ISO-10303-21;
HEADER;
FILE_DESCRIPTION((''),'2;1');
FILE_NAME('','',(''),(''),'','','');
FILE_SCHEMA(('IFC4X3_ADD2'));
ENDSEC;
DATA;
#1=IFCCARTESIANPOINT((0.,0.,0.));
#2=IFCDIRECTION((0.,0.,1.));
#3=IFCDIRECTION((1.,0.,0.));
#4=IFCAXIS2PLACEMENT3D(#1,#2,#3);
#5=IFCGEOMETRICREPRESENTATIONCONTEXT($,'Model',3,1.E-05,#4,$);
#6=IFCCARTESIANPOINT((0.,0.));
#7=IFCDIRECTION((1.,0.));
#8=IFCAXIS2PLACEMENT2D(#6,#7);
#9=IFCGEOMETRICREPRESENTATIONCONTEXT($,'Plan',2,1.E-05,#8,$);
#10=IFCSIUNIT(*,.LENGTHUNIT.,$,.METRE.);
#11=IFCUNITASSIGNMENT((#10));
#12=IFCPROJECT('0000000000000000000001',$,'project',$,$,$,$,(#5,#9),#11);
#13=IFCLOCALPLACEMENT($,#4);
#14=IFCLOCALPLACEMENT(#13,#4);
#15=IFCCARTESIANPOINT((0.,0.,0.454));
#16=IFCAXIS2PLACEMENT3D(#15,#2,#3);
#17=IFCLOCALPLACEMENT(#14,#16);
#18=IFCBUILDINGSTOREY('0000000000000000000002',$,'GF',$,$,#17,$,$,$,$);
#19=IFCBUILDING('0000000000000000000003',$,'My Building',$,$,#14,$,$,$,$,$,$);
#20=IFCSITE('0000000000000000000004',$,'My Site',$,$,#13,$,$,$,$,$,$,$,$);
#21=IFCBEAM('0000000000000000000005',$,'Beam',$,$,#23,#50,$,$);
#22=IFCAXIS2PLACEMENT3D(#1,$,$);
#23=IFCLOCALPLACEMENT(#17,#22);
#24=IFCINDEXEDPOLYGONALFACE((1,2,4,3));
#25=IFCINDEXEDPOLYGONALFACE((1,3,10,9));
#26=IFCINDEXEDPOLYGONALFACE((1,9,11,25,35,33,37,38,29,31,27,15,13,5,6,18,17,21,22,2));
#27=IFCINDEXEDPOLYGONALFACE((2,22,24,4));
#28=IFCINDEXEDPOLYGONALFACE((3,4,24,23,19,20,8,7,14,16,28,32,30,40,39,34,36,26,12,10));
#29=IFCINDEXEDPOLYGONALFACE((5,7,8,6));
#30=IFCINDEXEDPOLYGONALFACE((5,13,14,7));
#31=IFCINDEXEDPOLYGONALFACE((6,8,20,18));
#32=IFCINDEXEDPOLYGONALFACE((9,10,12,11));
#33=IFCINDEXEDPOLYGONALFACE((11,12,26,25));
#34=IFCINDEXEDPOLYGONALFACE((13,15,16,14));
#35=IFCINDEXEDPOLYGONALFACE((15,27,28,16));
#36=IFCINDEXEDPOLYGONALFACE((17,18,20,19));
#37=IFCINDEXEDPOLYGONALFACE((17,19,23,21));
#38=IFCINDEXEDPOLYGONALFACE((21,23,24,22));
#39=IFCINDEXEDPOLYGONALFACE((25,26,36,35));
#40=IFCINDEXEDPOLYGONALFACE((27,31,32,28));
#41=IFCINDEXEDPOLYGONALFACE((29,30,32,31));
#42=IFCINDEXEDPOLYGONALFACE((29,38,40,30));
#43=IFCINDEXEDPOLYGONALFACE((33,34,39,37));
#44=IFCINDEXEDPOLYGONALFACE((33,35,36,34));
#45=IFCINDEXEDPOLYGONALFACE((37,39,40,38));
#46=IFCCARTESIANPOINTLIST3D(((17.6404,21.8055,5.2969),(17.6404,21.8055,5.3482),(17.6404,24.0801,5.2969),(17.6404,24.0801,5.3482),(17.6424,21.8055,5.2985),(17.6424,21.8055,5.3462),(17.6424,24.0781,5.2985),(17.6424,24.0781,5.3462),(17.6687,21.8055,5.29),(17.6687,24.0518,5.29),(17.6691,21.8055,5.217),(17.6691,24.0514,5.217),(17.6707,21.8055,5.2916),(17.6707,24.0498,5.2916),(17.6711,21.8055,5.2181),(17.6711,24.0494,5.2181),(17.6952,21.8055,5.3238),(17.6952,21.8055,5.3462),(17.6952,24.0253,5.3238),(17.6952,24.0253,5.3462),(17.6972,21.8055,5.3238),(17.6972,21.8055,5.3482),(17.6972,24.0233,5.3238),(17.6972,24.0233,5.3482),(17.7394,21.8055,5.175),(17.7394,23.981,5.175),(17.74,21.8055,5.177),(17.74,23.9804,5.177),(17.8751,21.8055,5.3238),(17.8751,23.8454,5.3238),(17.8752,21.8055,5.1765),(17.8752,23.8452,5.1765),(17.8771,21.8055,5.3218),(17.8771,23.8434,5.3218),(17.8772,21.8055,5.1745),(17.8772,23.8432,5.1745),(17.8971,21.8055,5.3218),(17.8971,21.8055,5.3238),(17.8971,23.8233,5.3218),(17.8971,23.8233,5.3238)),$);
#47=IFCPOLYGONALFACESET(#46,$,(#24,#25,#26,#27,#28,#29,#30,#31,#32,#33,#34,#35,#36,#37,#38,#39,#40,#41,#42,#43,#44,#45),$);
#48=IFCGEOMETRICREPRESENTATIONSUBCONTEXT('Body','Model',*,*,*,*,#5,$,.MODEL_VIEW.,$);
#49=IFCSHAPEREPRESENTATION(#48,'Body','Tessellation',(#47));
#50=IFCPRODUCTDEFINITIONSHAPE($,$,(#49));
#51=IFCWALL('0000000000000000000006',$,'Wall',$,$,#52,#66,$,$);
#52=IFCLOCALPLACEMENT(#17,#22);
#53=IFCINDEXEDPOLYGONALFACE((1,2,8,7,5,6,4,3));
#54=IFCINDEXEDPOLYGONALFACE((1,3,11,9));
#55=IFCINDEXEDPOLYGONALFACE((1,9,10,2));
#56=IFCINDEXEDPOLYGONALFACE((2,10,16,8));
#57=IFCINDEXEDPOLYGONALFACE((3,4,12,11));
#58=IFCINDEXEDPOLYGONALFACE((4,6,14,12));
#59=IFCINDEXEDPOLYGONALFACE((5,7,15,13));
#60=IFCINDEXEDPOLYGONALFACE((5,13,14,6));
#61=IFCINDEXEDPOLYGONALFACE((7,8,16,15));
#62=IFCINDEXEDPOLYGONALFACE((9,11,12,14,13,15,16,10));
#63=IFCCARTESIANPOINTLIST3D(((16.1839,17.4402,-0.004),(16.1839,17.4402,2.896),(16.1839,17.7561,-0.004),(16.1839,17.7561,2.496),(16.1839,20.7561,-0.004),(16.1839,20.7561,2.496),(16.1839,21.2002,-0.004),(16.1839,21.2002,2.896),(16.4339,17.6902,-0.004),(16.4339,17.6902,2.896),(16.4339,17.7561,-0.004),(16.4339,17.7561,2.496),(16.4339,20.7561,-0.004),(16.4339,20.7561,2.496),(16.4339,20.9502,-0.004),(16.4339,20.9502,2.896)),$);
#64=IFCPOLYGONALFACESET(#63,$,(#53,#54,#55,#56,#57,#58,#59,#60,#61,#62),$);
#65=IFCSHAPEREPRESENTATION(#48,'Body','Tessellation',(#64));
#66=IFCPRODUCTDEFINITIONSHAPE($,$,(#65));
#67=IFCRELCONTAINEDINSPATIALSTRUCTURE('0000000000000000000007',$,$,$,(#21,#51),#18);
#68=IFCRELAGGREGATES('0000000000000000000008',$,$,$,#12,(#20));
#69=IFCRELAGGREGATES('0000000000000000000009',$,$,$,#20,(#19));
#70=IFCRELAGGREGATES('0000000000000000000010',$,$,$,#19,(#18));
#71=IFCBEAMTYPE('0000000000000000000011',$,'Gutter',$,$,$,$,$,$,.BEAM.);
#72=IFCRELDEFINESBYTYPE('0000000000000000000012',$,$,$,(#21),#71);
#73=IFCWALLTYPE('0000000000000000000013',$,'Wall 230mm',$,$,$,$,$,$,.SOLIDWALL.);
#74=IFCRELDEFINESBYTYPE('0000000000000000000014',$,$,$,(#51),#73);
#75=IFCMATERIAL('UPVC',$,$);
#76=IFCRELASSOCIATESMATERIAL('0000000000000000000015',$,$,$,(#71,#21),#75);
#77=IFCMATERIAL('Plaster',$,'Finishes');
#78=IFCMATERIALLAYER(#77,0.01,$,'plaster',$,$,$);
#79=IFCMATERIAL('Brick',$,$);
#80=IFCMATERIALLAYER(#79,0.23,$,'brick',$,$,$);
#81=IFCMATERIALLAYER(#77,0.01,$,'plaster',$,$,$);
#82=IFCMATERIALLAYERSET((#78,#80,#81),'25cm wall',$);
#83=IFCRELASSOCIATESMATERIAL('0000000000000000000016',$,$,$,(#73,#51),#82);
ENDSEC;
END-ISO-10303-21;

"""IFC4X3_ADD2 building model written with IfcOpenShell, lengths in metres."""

from ifc_helpers import new_model, si_unit, frame, origin_with_axes, origin_2d_with_axis, place, context, subcontext, project, spatial, line, indexed_curve, outline, extrude, clip, halfspace, source, transform, mapped, material, layer, layer_set, layer_usage, material_profile, profile_set, profile_usage, type_object, element, save


model = new_model("IFC4X3_ADD2")

# Units and contexts
model_context = context("Model", 3, precision=1e-05, world=origin_with_axes())
plan_context = context("Plan", 2, precision=1e-05, world=origin_2d_with_axis())
body_context = subcontext(model_context, "Body", "Model", "MODEL_VIEW")
ifc_project = project(units=[si_unit("LENGTHUNIT", "METRE")], contexts=[model_context, plan_context])

# Site, building, storey
site_placement = place(None, origin_with_axes())
site = spatial("IfcSite", under=ifc_project, at=site_placement, Name="My Site")
building_placement = place(site_placement, origin_with_axes())
building = spatial("IfcBuilding", under=site, at=building_placement, Name="My Building")
storey_placement = place(building_placement, frame((0.0, 0.0, 0.454), z_axis=(0.0, 0.0, 1.0), x_axis=(1.0, 0.0, 0.0)))
storey = spatial("IfcBuildingStorey", under=building, at=storey_placement, Name="GF")

# Shared definitions
ifc_material_1 = material(Name="UPVC")

# Beam
ifc_material_profile_1 = material_profile(ifc_material_1, outline(indexed_curve([(0.0548, 0.1717), (0.002, 0.1717), (0.002, 0.124), (0.0303, 0.1171), (0.0307, 0.0436), (0.0996, 0.0025), (0.2349, 0.002), (0.2347, 0.1494), (0.2567, 0.1494), (0.2567, 0.1474), (0.2367, 0.1474), (0.2369, 0.0), (0.0991, 0.0005), (0.0287, 0.0425), (0.0283, 0.1155), (0.0, 0.1224), (0.0, 0.1737), (0.0568, 0.1737), (0.0568, 0.1494), (0.0548, 0.1494), (0.0548, 0.1717)])))
ifc_profile_set_1 = profile_set([ifc_material_profile_1])
beam_type_1 = type_object("IfcBeamType", Name="Gutter", PredefinedType="BEAM", material=ifc_profile_set_1)
ifc_profile_usage_1 = profile_usage(ifc_profile_set_1)
beam_1_placement = place(storey_placement, frame((17.6404, 24.0801, 5.1745), z_axis=(0.0, -1.0, 0.0), x_axis=(1.0, 0.0, 0.0)))
element("IfcBeam", 1, at=beam_1_placement, inside=storey, type_object=beam_type_1, material=ifc_profile_usage_1, Name="Beam", context=body_context, shape_type="Clipping", body=[
    clip(extrude(outline(indexed_curve([(0.0548, 0.1717), (0.002, 0.1717), (0.002, 0.124), (0.0303, 0.1171), (0.0307, 0.0436), (0.0996, 0.0025), (0.2349, 0.002), (0.2347, 0.1494), (0.2567, 0.1494), (0.2567, 0.1474), (0.2367, 0.1474), (0.2369, 0.0), (0.0991, 0.0005), (0.0287, 0.0425), (0.0283, 0.1155), (0.0, 0.1224), (0.0, 0.1737), (0.0568, 0.1737), (0.0568, 0.1494), (0.0548, 0.1494), (0.0548, 0.1717)])), origin_with_axes(), (0.0, 0.0, 1.0), 2.2745), halfspace(frame((0.0, -5.6285, 0.0), z_axis=(0.707106, 0.0, -0.707107), x_axis=(0.0, -1.0, 0.0)), False)),
])

# Wall, opening
ifc_material_2 = material(Name="Plaster", Category="Finishes")
ifc_layer_1 = layer(ifc_material_2, 0.01, Name="plaster")
ifc_material_3 = material(Name="Brick")
ifc_layer_2 = layer(ifc_material_3, 0.23, Name="brick")
ifc_layer_3 = layer(ifc_material_2, 0.01, Name="plaster")
ifc_layer_set_1 = layer_set([ifc_layer_1, ifc_layer_2, ifc_layer_3], Name="25cm wall")
ifc_layer_usage_1 = layer_usage(ifc_layer_set_1, "AXIS2", "NEGATIVE", 0.0)
wall_type = type_object("IfcWallType", Name="Wall 230mm", PredefinedType="SOLIDWALL", material=ifc_layer_set_1)
wall_placement = place(storey_placement, frame((16.1839, 17.4402, -0.004), z_axis=(0.0, 0.0, 1.0), x_axis=(0.000001, 1.0, 0.0)))
wall = element("IfcWall", 2, at=wall_placement, inside=storey, type_object=wall_type, material=ifc_layer_usage_1, Name="Wall", context=body_context, shape_type="SweptSolid", body=[
    extrude(outline(indexed_curve([(0.25, -0.25), (0.0, 0.0), (3.76, 0.0), (3.51, -0.25)], segments=[line(1, 2, 3, 4, 1)])), origin_with_axes(), (0.0, 0.0, 1.0), 2.9),
])
shared_shape = source(origin_with_axes(), body_context, "Body", "SweptSolid", [
    extrude(outline(indexed_curve([(0.0, 0.0), (3.0, 0.0), (3.0, 2.5), (0.0, 2.5)], segments=[line(1, 2, 3, 4, 1)])), frame((0.0, -0.6, 0.0), z_axis=(0.0, -1.0, 0.0), x_axis=(1.0, 0.0, 0.0)), (0.0, 0.0, -1.0), 1.2),
])
opening_placement = place(wall_placement, frame((0.3159, 0.0, 0.0), z_axis=(0.0, 0.0, 1.0), x_axis=(1.0, 0.0, 0.0)))
element("IfcOpeningElement", 3, at=opening_placement, cuts=wall, PredefinedType="OPENING", context=body_context, shape_type="MappedRepresentation", body=[
    mapped(shared_shape, transform((0.0, 0.0, 0.0), x_axis=(1.0, 0.0, 0.0), y_axis=(0.0, 1.0, 0.0), z_axis=(0.0, 0.0, 1.0), scale=1.0)),
])

save(model, "model.ifc")
